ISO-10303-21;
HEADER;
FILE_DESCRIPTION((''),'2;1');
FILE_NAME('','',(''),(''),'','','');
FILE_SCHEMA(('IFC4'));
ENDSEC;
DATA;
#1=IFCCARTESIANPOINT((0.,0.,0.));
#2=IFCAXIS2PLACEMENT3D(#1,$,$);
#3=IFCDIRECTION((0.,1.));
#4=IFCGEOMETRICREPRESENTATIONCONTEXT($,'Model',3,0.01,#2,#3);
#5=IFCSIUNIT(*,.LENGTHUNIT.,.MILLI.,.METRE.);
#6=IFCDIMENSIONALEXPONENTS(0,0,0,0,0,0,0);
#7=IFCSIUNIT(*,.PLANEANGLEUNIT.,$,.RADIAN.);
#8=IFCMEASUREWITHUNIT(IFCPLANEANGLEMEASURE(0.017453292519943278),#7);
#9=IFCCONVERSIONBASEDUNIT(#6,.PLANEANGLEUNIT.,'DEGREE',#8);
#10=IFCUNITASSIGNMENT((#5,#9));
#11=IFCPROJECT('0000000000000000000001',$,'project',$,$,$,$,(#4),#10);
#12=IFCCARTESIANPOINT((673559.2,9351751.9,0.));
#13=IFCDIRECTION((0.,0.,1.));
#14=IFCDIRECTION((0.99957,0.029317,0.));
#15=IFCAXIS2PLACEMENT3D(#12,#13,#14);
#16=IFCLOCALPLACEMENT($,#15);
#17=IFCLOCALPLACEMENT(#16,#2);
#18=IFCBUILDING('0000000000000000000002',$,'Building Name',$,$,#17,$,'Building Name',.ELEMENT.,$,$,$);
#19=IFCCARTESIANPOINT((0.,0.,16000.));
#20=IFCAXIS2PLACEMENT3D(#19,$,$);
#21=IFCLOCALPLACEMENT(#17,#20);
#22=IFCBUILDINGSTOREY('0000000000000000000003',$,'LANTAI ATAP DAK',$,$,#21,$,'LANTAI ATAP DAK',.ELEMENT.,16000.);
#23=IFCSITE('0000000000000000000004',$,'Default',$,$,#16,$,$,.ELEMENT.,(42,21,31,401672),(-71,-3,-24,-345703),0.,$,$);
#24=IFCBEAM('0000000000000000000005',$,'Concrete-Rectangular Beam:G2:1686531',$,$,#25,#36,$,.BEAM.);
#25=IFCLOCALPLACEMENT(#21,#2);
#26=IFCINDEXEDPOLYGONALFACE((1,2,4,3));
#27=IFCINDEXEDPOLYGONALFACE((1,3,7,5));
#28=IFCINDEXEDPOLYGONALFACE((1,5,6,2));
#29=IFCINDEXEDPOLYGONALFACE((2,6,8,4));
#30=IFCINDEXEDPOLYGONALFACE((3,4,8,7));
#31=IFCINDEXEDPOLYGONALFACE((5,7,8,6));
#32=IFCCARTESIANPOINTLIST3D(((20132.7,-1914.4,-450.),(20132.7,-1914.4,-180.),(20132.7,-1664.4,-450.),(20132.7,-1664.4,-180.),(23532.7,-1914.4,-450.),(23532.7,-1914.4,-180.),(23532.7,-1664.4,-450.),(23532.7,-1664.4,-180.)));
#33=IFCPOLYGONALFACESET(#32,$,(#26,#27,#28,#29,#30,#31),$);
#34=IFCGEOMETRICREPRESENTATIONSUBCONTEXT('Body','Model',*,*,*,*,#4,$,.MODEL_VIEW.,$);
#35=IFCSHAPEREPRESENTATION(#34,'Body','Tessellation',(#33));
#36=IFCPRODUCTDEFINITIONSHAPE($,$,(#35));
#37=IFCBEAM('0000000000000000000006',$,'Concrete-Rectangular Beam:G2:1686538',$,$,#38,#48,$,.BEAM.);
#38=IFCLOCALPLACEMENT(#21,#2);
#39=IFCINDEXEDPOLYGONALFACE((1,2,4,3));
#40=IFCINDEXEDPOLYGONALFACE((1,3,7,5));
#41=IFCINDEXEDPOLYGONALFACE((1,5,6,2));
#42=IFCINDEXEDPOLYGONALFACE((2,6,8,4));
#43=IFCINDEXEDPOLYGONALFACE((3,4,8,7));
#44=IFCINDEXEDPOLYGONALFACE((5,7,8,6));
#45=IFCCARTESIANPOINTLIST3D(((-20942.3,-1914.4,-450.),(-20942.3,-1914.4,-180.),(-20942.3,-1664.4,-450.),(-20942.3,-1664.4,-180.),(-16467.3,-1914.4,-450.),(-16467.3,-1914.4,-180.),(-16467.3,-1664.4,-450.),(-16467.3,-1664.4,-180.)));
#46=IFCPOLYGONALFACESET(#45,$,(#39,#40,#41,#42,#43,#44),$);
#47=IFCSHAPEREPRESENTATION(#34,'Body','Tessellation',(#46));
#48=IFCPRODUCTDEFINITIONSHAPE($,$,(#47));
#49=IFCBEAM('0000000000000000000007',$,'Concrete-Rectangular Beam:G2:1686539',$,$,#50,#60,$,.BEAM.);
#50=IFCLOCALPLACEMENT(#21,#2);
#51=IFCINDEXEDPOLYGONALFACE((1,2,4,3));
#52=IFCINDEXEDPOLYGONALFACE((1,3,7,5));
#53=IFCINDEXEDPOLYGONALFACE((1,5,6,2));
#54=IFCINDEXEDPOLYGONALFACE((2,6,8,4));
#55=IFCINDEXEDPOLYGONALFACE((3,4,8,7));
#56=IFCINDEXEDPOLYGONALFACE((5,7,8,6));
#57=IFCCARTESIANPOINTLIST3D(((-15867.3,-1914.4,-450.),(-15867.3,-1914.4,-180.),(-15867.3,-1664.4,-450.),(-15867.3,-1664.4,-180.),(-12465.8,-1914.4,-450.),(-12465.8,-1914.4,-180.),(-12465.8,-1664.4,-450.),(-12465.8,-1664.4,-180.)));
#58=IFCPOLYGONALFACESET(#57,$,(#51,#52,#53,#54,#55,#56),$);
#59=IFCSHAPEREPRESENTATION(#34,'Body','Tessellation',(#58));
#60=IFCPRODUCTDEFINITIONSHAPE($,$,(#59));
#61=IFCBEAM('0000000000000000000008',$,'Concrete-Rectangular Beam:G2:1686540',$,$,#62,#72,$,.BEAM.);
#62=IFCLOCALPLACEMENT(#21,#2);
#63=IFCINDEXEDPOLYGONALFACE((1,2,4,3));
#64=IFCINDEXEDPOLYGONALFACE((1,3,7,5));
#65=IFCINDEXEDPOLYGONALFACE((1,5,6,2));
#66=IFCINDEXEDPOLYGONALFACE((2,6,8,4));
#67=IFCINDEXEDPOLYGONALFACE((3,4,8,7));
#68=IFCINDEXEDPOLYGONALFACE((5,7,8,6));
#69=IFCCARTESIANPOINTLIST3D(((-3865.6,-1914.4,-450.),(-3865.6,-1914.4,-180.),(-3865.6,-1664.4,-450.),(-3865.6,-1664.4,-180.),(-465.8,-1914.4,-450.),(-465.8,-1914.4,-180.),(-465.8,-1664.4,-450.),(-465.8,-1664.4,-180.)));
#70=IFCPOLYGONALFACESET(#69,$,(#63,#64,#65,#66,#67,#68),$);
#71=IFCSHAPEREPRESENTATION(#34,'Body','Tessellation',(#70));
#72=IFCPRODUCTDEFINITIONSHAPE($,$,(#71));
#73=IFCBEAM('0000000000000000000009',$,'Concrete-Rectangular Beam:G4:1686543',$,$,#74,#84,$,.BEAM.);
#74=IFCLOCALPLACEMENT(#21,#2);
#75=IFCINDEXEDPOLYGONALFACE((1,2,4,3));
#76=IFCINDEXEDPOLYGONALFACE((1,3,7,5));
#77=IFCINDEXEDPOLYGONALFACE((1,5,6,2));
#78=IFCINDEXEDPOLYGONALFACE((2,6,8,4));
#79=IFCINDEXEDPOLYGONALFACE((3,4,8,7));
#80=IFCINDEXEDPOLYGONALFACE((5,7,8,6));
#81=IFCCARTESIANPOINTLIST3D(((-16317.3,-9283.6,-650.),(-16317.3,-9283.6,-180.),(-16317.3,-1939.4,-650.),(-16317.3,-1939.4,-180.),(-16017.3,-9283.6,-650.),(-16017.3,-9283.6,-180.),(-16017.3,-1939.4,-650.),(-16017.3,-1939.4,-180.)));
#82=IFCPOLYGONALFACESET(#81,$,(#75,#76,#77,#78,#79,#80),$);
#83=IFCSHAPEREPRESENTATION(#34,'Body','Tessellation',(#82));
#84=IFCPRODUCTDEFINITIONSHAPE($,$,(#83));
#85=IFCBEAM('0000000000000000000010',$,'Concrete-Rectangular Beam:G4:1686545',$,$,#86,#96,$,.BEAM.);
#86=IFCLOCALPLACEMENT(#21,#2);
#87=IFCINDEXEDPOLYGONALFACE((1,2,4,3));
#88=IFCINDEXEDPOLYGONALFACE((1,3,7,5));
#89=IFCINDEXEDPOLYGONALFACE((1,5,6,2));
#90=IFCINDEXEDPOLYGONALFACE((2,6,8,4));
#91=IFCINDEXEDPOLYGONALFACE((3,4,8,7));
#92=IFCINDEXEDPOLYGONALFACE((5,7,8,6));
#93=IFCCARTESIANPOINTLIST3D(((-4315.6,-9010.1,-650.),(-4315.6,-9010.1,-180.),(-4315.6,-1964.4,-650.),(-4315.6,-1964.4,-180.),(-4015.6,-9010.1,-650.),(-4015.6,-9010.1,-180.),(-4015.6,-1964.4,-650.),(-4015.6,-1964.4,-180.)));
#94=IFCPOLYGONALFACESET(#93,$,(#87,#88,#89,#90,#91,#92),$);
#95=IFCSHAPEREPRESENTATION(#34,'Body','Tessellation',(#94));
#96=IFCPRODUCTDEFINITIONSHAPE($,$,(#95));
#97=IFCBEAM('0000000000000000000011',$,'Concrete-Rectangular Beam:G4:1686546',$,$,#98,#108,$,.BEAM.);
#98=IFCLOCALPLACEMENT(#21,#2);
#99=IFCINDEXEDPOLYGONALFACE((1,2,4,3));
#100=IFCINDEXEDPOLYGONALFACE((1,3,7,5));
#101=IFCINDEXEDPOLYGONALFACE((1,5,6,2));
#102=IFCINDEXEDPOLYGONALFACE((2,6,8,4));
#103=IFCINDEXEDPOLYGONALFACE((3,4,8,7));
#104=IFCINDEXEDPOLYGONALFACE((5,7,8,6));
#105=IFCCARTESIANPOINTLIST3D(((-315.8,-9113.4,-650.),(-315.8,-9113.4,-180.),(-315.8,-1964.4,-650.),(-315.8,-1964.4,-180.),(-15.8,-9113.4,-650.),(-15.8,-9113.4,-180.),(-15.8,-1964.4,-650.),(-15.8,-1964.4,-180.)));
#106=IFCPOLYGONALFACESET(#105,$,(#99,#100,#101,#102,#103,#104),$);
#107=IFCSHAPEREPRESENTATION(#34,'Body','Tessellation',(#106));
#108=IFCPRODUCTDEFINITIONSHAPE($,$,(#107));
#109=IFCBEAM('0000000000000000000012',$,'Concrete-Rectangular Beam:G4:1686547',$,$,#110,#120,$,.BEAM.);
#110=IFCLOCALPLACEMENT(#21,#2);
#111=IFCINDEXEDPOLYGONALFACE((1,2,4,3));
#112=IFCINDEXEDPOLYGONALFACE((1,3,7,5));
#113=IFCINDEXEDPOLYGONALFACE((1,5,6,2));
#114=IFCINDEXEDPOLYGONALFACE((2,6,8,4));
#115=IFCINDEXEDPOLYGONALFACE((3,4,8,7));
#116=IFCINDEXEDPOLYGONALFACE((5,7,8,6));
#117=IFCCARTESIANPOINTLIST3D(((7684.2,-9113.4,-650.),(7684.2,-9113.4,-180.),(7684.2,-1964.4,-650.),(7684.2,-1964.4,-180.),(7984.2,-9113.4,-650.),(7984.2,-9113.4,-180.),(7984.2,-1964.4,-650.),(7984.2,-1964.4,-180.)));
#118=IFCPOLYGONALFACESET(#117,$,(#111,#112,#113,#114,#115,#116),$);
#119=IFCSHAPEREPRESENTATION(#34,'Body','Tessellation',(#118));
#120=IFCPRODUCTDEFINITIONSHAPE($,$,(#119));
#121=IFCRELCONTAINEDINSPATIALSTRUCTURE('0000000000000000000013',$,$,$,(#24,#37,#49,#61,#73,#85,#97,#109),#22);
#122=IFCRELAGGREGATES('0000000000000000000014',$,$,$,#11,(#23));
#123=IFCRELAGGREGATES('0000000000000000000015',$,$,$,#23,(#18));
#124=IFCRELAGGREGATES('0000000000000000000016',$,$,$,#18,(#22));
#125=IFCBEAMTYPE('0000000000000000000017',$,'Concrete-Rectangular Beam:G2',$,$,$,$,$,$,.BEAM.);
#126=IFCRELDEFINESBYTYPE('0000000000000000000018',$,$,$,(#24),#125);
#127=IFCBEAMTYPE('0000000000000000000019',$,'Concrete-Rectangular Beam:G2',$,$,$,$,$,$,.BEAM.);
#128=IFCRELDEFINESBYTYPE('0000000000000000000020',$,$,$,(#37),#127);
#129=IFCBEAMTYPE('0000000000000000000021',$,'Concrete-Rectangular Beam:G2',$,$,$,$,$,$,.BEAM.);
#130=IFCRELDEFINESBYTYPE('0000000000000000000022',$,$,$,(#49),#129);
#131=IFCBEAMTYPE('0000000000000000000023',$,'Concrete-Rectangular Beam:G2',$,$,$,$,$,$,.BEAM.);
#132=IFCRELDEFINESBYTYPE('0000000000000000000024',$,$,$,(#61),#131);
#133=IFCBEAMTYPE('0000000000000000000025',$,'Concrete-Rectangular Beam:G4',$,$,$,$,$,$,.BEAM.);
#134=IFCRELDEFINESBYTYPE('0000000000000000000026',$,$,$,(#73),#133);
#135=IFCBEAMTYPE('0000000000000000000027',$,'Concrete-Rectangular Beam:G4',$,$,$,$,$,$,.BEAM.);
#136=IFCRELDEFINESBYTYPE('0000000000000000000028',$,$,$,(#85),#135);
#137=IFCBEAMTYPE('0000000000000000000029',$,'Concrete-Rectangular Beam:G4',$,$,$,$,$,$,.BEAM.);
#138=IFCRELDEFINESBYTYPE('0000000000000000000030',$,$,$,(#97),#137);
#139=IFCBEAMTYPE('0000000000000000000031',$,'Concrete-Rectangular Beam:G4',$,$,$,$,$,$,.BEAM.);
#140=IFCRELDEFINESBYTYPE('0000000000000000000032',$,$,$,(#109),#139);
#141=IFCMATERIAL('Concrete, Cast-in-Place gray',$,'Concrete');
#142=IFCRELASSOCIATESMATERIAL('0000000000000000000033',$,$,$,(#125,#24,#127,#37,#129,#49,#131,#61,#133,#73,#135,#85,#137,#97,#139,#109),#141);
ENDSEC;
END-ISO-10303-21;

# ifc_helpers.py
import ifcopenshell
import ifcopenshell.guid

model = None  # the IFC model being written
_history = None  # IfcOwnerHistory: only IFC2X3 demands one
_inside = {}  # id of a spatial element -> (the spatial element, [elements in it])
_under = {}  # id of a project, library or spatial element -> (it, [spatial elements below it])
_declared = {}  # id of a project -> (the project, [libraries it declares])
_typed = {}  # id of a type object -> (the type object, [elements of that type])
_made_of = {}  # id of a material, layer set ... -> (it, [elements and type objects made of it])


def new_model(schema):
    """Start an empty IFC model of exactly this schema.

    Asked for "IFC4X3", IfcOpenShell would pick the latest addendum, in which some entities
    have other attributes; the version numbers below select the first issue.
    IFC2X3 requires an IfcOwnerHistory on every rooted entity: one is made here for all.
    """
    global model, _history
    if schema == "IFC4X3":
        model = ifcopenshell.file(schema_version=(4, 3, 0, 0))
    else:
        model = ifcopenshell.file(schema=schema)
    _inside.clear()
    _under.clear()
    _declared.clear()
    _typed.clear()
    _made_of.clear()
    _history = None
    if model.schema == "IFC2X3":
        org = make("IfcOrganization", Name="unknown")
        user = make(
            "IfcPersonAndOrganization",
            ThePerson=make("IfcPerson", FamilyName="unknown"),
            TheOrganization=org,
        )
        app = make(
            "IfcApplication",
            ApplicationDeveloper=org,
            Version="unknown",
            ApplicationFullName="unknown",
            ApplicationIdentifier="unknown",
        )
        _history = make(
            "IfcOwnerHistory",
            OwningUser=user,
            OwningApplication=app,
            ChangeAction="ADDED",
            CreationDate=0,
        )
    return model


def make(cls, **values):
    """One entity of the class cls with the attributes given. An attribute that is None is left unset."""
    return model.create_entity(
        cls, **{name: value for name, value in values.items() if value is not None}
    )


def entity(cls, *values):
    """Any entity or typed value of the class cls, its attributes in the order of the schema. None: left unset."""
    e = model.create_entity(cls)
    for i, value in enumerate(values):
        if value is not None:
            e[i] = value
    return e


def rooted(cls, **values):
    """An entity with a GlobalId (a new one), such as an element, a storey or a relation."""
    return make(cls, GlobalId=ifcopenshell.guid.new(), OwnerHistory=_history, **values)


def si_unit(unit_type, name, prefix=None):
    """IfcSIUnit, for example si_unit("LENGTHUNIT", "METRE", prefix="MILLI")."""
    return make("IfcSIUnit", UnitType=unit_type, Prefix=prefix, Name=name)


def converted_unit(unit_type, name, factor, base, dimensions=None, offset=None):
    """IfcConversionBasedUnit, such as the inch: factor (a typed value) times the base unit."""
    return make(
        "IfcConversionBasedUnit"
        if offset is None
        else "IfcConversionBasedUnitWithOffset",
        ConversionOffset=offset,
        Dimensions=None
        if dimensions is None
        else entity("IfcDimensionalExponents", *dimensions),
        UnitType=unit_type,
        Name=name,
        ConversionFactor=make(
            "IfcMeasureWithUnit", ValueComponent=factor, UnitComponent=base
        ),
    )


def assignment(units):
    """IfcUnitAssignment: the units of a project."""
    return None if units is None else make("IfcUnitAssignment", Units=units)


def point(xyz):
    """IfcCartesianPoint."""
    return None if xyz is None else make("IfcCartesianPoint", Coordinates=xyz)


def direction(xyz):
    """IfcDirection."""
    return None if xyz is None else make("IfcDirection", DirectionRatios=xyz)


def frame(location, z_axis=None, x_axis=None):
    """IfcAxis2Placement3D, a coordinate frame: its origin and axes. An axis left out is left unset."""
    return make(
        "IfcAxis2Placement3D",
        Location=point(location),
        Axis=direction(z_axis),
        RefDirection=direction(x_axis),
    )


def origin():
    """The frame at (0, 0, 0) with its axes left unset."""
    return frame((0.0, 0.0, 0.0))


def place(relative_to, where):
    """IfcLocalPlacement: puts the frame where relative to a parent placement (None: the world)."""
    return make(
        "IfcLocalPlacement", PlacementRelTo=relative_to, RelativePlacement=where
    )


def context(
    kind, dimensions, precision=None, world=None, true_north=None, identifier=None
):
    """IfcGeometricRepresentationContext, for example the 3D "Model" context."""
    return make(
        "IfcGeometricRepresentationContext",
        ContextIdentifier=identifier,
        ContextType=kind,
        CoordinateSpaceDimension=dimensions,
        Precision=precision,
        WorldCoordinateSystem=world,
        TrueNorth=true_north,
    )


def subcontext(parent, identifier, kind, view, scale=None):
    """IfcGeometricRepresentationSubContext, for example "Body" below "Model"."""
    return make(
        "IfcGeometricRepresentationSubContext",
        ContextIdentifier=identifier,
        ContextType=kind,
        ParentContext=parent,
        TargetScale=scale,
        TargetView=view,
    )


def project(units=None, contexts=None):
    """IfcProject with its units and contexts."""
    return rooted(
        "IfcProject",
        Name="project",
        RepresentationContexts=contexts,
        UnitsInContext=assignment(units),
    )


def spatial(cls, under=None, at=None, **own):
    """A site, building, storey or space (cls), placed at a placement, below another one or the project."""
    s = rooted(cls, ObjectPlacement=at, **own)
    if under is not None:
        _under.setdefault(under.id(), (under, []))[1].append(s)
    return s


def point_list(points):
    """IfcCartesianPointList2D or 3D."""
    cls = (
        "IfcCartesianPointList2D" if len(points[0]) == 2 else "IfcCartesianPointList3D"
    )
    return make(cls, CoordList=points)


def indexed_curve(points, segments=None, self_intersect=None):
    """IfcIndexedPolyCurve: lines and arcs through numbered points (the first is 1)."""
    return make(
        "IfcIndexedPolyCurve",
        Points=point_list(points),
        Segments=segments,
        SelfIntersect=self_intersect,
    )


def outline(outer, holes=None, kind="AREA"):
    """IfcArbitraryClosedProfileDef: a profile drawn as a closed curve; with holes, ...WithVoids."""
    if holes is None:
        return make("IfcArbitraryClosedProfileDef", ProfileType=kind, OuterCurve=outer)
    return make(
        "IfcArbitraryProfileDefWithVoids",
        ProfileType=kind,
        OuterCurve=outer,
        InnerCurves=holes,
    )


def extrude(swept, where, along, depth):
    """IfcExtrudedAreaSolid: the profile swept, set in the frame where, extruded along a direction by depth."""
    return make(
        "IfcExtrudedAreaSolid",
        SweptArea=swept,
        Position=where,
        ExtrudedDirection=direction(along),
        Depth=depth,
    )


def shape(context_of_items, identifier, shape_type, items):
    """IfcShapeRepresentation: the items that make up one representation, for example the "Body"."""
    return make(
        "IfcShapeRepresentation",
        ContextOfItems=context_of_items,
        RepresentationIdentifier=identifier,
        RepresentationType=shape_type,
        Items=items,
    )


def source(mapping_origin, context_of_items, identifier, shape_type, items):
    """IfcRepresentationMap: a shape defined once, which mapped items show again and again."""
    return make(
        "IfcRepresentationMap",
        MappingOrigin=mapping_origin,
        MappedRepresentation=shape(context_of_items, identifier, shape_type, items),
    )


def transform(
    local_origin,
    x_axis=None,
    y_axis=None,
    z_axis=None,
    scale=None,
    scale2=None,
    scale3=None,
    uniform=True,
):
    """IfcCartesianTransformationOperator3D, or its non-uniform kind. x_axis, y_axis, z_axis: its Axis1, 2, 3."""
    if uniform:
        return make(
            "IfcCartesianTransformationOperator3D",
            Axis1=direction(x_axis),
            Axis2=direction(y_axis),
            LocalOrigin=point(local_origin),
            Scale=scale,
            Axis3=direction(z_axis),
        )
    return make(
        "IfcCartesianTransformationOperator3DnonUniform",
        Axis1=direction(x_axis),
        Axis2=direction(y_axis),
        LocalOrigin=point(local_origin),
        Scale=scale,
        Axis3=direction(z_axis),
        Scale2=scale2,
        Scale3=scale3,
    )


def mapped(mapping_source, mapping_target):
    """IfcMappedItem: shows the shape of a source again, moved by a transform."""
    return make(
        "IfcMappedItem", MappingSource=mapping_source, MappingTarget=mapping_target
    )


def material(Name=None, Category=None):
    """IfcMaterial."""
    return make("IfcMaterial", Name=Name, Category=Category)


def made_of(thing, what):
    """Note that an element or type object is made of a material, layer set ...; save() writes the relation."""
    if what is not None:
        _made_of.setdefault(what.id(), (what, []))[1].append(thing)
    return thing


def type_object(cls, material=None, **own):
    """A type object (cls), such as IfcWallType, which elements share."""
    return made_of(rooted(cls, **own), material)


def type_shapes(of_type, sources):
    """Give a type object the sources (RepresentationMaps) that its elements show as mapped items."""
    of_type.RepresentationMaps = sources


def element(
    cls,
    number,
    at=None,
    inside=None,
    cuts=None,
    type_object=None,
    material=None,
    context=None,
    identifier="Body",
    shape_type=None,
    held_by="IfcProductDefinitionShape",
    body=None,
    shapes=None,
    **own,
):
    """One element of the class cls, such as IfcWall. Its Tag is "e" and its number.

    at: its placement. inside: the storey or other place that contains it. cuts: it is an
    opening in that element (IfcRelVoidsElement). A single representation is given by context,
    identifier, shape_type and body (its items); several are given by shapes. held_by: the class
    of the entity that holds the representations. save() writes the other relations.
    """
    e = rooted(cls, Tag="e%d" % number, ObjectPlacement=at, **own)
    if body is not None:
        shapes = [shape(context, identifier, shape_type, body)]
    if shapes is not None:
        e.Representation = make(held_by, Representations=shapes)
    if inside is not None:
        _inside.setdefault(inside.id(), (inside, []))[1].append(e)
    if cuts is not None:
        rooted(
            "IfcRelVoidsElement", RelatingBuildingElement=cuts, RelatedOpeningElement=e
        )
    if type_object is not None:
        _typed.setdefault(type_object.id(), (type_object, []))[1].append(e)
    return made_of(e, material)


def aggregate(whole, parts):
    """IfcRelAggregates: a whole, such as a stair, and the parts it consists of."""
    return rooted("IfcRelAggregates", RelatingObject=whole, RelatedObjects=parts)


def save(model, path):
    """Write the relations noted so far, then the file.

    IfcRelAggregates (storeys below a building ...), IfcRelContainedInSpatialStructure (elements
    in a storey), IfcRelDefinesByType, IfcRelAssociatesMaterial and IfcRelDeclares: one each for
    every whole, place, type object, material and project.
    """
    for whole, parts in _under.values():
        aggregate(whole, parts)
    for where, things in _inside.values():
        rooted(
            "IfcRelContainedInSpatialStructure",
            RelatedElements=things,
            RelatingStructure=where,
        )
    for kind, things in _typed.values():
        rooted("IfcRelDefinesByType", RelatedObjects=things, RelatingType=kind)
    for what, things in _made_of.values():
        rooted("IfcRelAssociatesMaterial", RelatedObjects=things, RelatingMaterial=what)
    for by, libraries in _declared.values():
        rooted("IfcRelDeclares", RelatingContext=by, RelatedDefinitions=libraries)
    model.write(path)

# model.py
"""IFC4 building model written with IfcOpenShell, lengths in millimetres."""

from ifc_helpers import new_model, entity, si_unit, converted_unit, direction, frame, origin, place, context, subcontext, project, spatial, indexed_curve, outline, extrude, source, transform, mapped, material, type_object, type_shapes, element, save


model = new_model("IFC4")

# Units and contexts
model_context = context("Model", 3, precision=0.01, world=origin(), true_north=direction((0.0, 1.0)))
body_context = subcontext(model_context, "Body", "Model", "MODEL_VIEW")
ifc_project = project(units=[si_unit("LENGTHUNIT", "METRE", prefix="MILLI"), converted_unit("PLANEANGLEUNIT", "DEGREE", entity("IfcPlaneAngleMeasure", 0.017453292519943278), si_unit("PLANEANGLEUNIT", "RADIAN"), dimensions=[0, 0, 0, 0, 0, 0, 0])], contexts=[model_context])

# Site, building, storey
site_placement = place(None, frame((673559.2, 9351751.9, 0.0), z_axis=(0.0, 0.0, 1.0), x_axis=(0.99957, 0.029317, 0.0)))
site = spatial("IfcSite", under=ifc_project, at=site_placement, Name="Default", CompositionType="ELEMENT", RefLatitude=(42, 21, 31, 401672), RefLongitude=(-71, -3, -24, -345703), RefElevation=0.0)
building_placement = place(site_placement, origin())
building = spatial("IfcBuilding", under=site, at=building_placement, Name="Building Name", LongName="Building Name", CompositionType="ELEMENT")
storey_placement = place(building_placement, frame((0.0, 0.0, 16000.0)))
storey = spatial("IfcBuildingStorey", under=building, at=storey_placement, Name="LANTAI ATAP DAK", LongName="LANTAI ATAP DAK", CompositionType="ELEMENT", Elevation=16000.0)

# Beams
ifc_material = material(Name="Concrete, Cast-in-Place gray", Category="Concrete")
beam_type_1 = type_object("IfcBeamType", Name="Concrete-Rectangular Beam:G2", PredefinedType="BEAM", material=ifc_material)
shared_shape_1 = source(origin(), body_context, "Body", "SweptSolid", [
    extrude(outline(indexed_curve([(-135.0, -125.0), (135.0, -125.0), (135.0, 125.0), (-135.0, 125.0), (-135.0, -125.0)], self_intersect=False)), frame((23532.7, -1789.4, 15685.0), z_axis=(-1.0, 0.0, 0.0), x_axis=(0.0, 0.0, -1.0)), (0.0, 0.0, 1.0), 3400.0),
])
type_shapes(beam_type_1, [shared_shape_1])
beam_1_placement = place(storey_placement, frame((0.0, 0.0, -16000.0)))
element("IfcBeam", 1, at=beam_1_placement, inside=storey, type_object=beam_type_1, material=ifc_material, Name="Concrete-Rectangular Beam:G2:1686531", PredefinedType="BEAM", context=body_context, shape_type="MappedRepresentation", body=[
    mapped(shared_shape_1, transform((0.0, 0.0, 0.0), scale=1.0)),
])
beam_type_2 = type_object("IfcBeamType", Name="Concrete-Rectangular Beam:G2", PredefinedType="BEAM", material=ifc_material)
shared_shape_2 = source(origin(), body_context, "Body", "SweptSolid", [
    extrude(outline(indexed_curve([(-135.0, -125.0), (135.0, -125.0), (135.0, 125.0), (-135.0, 125.0), (-135.0, -125.0)], self_intersect=False)), frame((-20942.3, -1789.4, 15685.0), z_axis=(1.0, 0.0, 0.0), x_axis=(0.0, 0.0, -1.0)), (0.0, 0.0, 1.0), 4475.0),
])
type_shapes(beam_type_2, [shared_shape_2])
beam_2_placement = place(storey_placement, frame((0.0, 0.0, -16000.0)))
element("IfcBeam", 2, at=beam_2_placement, inside=storey, type_object=beam_type_2, material=ifc_material, Name="Concrete-Rectangular Beam:G2:1686538", PredefinedType="BEAM", context=body_context, shape_type="MappedRepresentation", body=[
    mapped(shared_shape_2, transform((0.0, 0.0, 0.0), scale=1.0)),
])
beam_type_3 = type_object("IfcBeamType", Name="Concrete-Rectangular Beam:G2", PredefinedType="BEAM", material=ifc_material)
shared_shape_3 = source(origin(), body_context, "Body", "SweptSolid", [
    extrude(outline(indexed_curve([(-135.0, -125.0), (135.0, -125.0), (135.0, 125.0), (-135.0, 125.0), (-135.0, -125.0)], self_intersect=False)), frame((-15867.3, -1789.4, 15685.0), z_axis=(1.0, 0.0, 0.0), x_axis=(0.0, 0.0, -1.0)), (0.0, 0.0, 1.0), 3401.5),
])
type_shapes(beam_type_3, [shared_shape_3])
beam_3_placement = place(storey_placement, frame((0.0, 0.0, -16000.0)))
element("IfcBeam", 3, at=beam_3_placement, inside=storey, type_object=beam_type_3, material=ifc_material, Name="Concrete-Rectangular Beam:G2:1686539", PredefinedType="BEAM", context=body_context, shape_type="MappedRepresentation", body=[
    mapped(shared_shape_3, transform((0.0, 0.0, 0.0), scale=1.0)),
])
beam_type_4 = type_object("IfcBeamType", Name="Concrete-Rectangular Beam:G2", PredefinedType="BEAM", material=ifc_material)
shared_shape_4 = source(origin(), body_context, "Body", "SweptSolid", [
    extrude(outline(indexed_curve([(-135.0, -125.0), (135.0, -125.0), (135.0, 125.0), (-135.0, 125.0), (-135.0, -125.0)], self_intersect=False)), frame((-465.8, -1789.4, 15685.0), z_axis=(-1.0, 0.0, 0.0), x_axis=(0.0, 0.0, -1.0)), (0.0, 0.0, 1.0), 3399.7),
])
type_shapes(beam_type_4, [shared_shape_4])
beam_4_placement = place(storey_placement, frame((0.0, 0.0, -16000.0)))
element("IfcBeam", 4, at=beam_4_placement, inside=storey, type_object=beam_type_4, material=ifc_material, Name="Concrete-Rectangular Beam:G2:1686540", PredefinedType="BEAM", context=body_context, shape_type="MappedRepresentation", body=[
    mapped(shared_shape_4, transform((0.0, 0.0, 0.0), scale=1.0)),
])
beam_type_5 = type_object("IfcBeamType", Name="Concrete-Rectangular Beam:G4", PredefinedType="BEAM", material=ifc_material)
shared_shape_5 = source(origin(), body_context, "Body", "SweptSolid", [
    extrude(outline(indexed_curve([(-150.0, -235.0), (150.0, -235.0), (150.0, 235.0), (-150.0, 235.0), (-150.0, -235.0)], self_intersect=False)), frame((-16167.3, -9283.6, 15585.0), z_axis=(0.0, 1.0, 0.0), x_axis=(-1.0, 0.0, 0.0)), (0.0, 0.0, 1.0), 7344.1),
])
type_shapes(beam_type_5, [shared_shape_5])
beam_5_placement = place(storey_placement, frame((0.0, 0.0, -16000.0)))
element("IfcBeam", 5, at=beam_5_placement, inside=storey, type_object=beam_type_5, material=ifc_material, Name="Concrete-Rectangular Beam:G4:1686543", PredefinedType="BEAM", context=body_context, shape_type="MappedRepresentation", body=[
    mapped(shared_shape_5, transform((0.0, 0.0, 0.0), scale=1.0)),
])
beam_type_6 = type_object("IfcBeamType", Name="Concrete-Rectangular Beam:G4", PredefinedType="BEAM", material=ifc_material)
shared_shape_6 = source(origin(), body_context, "Body", "SweptSolid", [
    extrude(outline(indexed_curve([(-150.0, -235.0), (150.0, -235.0), (150.0, 235.0), (-150.0, 235.0), (-150.0, -235.0)], self_intersect=False)), frame((-4165.6, -9010.1, 15585.0), z_axis=(0.0, 1.0, 0.0), x_axis=(-1.0, 0.0, 0.0)), (0.0, 0.0, 1.0), 7045.6),
])
type_shapes(beam_type_6, [shared_shape_6])
beam_6_placement = place(storey_placement, frame((0.0, 0.0, -16000.0)))
element("IfcBeam", 6, at=beam_6_placement, inside=storey, type_object=beam_type_6, material=ifc_material, Name="Concrete-Rectangular Beam:G4:1686545", PredefinedType="BEAM", context=body_context, shape_type="MappedRepresentation", body=[
    mapped(shared_shape_6, transform((0.0, 0.0, 0.0), scale=1.0)),
])
beam_type_7 = type_object("IfcBeamType", Name="Concrete-Rectangular Beam:G4", PredefinedType="BEAM", material=ifc_material)
shared_shape_7 = source(origin(), body_context, "Body", "SweptSolid", [
    extrude(outline(indexed_curve([(-150.0, -235.0), (150.0, -235.0), (150.0, 235.0), (-150.0, 235.0), (-150.0, -235.0)], self_intersect=False)), frame((-165.8, -9113.4, 15585.0), z_axis=(0.0, 1.0, 0.0), x_axis=(-1.0, 0.0, 0.0)), (0.0, 0.0, 1.0), 7149.0),
])
type_shapes(beam_type_7, [shared_shape_7])
beam_7_placement = place(storey_placement, frame((0.0, 0.0, -16000.0)))
element("IfcBeam", 7, at=beam_7_placement, inside=storey, type_object=beam_type_7, material=ifc_material, Name="Concrete-Rectangular Beam:G4:1686546", PredefinedType="BEAM", context=body_context, shape_type="MappedRepresentation", body=[
    mapped(shared_shape_7, transform((0.0, 0.0, 0.0), scale=1.0)),
])
beam_type_8 = type_object("IfcBeamType", Name="Concrete-Rectangular Beam:G4", PredefinedType="BEAM", material=ifc_material)
shared_shape_8 = source(origin(), body_context, "Body", "SweptSolid", [
    extrude(outline(indexed_curve([(-150.0, -235.0), (150.0, -235.0), (150.0, 235.0), (-150.0, 235.0), (-150.0, -235.0)], self_intersect=False)), frame((7834.2, -9113.4, 15585.0), z_axis=(0.0, 1.0, 0.0), x_axis=(-1.0, 0.0, 0.0)), (0.0, 0.0, 1.0), 7149.0),
])
type_shapes(beam_type_8, [shared_shape_8])
beam_8_placement = place(storey_placement, frame((0.0, 0.0, -16000.0)))
element("IfcBeam", 8, at=beam_8_placement, inside=storey, type_object=beam_type_8, material=ifc_material, Name="Concrete-Rectangular Beam:G4:1686547", PredefinedType="BEAM", context=body_context, shape_type="MappedRepresentation", body=[
    mapped(shared_shape_8, transform((0.0, 0.0, 0.0), scale=1.0)),
])

save(model, "model.ifc")
